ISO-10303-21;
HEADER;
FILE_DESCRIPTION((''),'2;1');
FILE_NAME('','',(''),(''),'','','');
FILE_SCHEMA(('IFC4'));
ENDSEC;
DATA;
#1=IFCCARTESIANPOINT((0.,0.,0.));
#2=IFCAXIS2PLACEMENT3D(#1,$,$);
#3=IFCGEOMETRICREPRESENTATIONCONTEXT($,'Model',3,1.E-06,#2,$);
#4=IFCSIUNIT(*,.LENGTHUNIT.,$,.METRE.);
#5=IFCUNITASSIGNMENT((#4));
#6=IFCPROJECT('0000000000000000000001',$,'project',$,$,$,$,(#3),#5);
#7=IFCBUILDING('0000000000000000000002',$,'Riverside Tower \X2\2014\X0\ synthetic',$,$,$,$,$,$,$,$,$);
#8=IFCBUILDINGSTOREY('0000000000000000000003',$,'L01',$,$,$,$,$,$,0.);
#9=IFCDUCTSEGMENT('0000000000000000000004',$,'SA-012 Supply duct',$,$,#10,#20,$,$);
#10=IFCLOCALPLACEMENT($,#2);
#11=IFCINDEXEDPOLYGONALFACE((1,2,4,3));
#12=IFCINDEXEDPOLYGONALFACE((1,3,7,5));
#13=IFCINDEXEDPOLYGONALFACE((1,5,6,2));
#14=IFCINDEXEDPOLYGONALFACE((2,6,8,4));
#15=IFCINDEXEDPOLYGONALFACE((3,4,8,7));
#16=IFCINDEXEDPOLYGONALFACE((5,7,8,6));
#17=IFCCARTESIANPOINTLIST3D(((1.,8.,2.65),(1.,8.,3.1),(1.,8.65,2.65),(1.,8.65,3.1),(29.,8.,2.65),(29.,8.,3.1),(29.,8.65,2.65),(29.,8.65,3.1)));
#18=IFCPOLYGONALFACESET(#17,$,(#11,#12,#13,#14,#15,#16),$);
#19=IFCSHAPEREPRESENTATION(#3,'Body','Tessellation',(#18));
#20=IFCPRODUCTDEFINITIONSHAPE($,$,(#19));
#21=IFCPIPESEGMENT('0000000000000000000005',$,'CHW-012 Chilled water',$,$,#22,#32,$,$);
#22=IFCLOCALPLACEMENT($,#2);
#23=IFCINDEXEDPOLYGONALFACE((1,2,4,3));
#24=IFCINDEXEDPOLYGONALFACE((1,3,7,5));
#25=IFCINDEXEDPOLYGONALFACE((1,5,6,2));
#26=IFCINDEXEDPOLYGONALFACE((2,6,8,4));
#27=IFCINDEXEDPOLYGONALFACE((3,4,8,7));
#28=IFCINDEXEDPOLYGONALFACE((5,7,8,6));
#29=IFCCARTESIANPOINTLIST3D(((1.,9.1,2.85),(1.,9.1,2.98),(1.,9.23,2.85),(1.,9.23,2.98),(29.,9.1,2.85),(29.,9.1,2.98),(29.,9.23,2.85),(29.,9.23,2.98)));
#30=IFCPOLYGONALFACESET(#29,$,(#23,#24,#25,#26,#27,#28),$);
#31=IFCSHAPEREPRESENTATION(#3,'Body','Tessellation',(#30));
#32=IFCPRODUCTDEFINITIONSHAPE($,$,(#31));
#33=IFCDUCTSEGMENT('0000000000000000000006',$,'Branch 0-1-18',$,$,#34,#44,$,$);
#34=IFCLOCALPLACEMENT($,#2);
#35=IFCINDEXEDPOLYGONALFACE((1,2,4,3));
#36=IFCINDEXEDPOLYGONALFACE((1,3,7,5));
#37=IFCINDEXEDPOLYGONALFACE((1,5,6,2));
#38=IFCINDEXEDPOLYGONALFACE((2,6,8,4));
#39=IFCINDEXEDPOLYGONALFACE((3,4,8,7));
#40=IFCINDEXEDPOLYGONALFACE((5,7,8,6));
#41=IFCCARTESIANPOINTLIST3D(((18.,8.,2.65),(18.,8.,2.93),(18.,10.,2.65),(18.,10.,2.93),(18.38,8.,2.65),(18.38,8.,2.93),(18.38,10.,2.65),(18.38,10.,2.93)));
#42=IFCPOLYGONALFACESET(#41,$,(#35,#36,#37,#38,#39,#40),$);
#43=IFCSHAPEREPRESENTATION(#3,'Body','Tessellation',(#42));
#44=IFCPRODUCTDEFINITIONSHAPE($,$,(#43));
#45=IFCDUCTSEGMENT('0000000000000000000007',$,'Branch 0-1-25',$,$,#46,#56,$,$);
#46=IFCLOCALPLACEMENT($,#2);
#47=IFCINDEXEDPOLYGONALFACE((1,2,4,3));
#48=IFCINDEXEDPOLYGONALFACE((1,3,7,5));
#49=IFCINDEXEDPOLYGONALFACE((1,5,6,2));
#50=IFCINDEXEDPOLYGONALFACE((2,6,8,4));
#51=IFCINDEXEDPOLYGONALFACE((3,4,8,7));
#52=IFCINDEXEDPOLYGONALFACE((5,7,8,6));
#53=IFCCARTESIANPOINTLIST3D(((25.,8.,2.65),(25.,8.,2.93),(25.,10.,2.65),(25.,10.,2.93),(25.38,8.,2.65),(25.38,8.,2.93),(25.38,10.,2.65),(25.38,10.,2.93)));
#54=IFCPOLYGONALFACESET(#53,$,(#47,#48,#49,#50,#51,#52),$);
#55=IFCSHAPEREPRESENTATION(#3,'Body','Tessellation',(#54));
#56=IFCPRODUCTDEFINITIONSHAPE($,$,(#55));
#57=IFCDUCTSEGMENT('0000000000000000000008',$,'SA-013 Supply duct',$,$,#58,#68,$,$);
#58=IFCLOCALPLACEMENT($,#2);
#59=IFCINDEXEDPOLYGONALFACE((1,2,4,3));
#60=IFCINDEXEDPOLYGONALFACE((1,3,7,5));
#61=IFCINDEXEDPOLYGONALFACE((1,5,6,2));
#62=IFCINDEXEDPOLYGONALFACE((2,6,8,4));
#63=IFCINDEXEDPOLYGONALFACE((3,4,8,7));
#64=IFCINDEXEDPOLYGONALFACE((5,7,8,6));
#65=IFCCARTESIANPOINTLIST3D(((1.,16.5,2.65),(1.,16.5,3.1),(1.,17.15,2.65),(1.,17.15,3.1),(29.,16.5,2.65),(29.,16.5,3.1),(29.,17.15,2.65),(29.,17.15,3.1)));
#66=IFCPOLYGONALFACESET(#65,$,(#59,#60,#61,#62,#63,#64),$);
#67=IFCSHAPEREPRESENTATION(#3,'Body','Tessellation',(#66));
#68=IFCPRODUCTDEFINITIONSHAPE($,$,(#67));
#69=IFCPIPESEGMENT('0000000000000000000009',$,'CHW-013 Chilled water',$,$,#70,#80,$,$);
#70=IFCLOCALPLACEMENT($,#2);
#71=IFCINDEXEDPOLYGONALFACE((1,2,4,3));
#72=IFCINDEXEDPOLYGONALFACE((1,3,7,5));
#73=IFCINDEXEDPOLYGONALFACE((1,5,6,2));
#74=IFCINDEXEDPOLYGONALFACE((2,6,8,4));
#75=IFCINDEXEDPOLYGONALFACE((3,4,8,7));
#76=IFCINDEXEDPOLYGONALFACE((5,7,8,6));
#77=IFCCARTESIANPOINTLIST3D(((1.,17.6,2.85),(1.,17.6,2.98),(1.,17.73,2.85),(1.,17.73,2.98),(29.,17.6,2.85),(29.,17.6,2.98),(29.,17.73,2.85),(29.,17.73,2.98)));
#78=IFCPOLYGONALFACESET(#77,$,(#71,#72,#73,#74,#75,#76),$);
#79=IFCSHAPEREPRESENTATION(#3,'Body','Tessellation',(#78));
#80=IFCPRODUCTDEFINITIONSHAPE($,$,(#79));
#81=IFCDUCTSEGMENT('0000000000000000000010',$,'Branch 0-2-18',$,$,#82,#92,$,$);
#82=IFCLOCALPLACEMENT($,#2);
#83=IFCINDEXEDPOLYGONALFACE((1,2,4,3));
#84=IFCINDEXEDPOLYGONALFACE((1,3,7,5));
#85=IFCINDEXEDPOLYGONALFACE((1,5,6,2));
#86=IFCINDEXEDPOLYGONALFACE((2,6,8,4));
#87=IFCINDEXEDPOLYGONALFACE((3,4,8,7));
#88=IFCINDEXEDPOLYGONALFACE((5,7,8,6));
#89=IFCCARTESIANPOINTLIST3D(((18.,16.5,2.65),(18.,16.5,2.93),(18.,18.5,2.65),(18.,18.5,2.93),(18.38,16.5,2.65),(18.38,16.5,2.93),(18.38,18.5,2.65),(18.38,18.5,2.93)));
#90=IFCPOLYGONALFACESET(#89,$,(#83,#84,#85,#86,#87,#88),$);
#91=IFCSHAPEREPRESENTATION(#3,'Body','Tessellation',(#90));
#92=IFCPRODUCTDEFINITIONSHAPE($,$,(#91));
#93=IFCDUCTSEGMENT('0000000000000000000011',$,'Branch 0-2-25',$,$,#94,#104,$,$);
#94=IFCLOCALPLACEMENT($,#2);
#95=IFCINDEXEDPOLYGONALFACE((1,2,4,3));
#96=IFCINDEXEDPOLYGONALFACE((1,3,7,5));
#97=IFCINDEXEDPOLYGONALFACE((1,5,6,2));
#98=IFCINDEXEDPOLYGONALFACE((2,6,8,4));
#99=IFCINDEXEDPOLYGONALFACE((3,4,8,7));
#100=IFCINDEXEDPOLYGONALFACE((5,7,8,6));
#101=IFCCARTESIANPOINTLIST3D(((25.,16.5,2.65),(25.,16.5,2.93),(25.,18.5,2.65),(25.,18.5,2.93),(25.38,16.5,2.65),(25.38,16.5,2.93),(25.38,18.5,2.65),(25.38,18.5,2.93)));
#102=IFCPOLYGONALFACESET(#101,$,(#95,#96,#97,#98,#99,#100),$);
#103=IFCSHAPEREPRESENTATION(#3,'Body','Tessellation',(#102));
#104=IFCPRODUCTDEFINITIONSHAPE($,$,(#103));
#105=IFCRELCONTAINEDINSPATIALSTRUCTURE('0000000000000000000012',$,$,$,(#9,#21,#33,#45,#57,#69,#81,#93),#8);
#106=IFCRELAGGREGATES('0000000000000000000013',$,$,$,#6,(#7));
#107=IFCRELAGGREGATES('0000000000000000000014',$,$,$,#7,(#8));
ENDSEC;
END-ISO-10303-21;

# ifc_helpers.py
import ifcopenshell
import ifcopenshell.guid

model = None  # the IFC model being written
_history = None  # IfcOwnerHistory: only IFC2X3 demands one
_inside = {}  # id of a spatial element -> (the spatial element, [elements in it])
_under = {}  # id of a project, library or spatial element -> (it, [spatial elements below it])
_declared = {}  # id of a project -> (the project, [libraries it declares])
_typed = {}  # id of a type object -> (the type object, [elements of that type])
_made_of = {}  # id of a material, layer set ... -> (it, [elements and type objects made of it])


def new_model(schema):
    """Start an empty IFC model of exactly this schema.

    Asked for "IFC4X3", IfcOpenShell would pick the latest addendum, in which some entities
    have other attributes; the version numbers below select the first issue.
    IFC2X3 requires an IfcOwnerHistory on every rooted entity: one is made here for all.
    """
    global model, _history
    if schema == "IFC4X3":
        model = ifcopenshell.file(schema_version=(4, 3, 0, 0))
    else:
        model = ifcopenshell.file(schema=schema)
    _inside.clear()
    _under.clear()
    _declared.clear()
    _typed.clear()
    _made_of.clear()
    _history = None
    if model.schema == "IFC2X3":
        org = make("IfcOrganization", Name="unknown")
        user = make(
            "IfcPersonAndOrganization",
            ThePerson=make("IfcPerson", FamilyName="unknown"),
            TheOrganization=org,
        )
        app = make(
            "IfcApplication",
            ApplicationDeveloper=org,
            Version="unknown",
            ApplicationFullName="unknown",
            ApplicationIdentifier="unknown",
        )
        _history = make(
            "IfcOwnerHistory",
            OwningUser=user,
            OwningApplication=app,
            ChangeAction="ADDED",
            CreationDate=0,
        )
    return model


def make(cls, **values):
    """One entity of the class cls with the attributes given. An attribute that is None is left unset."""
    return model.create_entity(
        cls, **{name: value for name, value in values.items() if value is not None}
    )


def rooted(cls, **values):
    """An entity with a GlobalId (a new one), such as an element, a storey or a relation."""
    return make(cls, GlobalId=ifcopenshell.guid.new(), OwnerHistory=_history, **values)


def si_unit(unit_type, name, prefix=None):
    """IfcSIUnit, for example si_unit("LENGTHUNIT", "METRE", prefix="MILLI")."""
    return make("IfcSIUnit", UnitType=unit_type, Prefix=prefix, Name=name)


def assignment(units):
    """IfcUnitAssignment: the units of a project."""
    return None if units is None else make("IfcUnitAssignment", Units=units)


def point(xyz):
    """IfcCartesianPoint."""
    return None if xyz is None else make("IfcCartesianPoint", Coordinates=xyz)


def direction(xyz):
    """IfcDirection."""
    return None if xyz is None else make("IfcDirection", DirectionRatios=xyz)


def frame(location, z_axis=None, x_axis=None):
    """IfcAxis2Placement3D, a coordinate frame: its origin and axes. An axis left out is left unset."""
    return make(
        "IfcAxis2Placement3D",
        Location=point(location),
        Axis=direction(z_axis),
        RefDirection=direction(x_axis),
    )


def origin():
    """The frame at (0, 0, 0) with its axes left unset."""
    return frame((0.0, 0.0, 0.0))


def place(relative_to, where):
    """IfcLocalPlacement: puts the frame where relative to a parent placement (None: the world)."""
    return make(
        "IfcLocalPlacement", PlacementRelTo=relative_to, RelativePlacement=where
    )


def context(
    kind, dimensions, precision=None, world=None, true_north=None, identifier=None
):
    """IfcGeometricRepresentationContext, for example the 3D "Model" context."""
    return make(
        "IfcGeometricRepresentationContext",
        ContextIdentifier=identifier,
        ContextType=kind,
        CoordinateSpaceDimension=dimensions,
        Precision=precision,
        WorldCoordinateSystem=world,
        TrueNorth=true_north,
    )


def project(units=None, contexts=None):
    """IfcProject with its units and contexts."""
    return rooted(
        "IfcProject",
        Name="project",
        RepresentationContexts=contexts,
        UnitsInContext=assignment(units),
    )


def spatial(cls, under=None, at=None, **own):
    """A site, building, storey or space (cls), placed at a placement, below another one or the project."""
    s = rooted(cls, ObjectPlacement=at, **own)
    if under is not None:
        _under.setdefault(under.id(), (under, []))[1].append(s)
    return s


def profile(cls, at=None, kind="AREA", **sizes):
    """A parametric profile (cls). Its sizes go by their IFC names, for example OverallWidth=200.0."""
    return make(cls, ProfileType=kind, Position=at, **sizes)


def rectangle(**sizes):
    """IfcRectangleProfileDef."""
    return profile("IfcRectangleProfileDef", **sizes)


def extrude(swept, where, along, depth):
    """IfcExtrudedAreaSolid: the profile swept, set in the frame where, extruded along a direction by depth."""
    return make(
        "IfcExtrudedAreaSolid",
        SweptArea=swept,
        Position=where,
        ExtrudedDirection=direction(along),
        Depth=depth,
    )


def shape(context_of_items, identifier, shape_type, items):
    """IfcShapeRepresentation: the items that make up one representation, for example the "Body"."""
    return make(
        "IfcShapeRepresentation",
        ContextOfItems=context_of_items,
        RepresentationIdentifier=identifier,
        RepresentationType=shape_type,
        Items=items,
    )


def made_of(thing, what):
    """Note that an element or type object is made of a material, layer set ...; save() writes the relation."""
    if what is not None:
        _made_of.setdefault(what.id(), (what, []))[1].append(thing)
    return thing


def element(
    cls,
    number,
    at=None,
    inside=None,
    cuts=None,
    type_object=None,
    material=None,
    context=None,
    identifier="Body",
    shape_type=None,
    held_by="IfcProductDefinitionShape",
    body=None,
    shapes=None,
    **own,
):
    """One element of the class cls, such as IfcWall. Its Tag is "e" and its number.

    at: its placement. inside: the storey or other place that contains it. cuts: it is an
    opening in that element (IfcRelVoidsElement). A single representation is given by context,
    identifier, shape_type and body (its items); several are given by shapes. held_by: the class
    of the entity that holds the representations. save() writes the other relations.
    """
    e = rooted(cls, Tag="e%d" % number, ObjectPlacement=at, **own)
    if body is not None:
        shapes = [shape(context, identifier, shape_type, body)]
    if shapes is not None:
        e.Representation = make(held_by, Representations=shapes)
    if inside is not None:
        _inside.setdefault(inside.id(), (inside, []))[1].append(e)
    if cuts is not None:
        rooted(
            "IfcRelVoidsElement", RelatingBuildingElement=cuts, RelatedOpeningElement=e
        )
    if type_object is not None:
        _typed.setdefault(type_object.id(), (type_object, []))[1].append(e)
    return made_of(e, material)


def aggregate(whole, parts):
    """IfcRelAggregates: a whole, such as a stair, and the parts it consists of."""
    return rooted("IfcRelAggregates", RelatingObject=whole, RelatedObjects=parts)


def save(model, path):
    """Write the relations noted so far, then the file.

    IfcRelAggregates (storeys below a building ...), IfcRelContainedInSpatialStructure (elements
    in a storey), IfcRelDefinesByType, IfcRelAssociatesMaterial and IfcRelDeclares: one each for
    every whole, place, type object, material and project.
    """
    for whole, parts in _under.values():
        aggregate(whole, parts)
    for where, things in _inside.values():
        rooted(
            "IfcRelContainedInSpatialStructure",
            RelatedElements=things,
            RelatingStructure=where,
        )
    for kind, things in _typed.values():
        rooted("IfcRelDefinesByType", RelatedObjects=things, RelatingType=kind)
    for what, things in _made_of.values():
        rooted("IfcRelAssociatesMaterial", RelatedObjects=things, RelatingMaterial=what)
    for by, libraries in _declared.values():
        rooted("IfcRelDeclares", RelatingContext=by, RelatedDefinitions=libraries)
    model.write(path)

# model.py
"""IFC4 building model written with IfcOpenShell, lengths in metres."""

from ifc_helpers import new_model, si_unit, frame, origin, place, context, project, spatial, rectangle, extrude, element, save


model = new_model("IFC4")

# Units and contexts
model_context = context("Model", 3, precision=1e-06, world=origin())
ifc_project = project(units=[si_unit("LENGTHUNIT", "METRE")], contexts=[model_context])

# Building, storey
building = spatial("IfcBuilding", under=ifc_project, Name="Riverside Tower — synthetic")
storey = spatial("IfcBuildingStorey", under=building, Name="L01", Elevation=0.0)

# Duct segment
duct_segment_1_placement = place(None, frame((15.0, 8.325, 2.65)))
element("IfcDuctSegment", 1, at=duct_segment_1_placement, inside=storey, Name="SA-012 Supply duct", context=model_context, shape_type="SweptSolid", body=[
    extrude(rectangle(XDim=28.0, YDim=0.65), origin(), (0.0, 0.0, 1.0), 0.45),
])

# Pipe segment
pipe_segment_1_placement = place(None, frame((15.0, 9.165, 2.85)))
element("IfcPipeSegment", 2, at=pipe_segment_1_placement, inside=storey, Name="CHW-012 Chilled water", context=model_context, shape_type="SweptSolid", body=[
    extrude(rectangle(XDim=28.0, YDim=0.13), origin(), (0.0, 0.0, 1.0), 0.13),
])

# Duct segments
for number, where, name in (
    (3, (18.19, 9.0, 2.65), "Branch 0-1-18"),
    (4, (25.19, 9.0, 2.65), "Branch 0-1-25"),
):
    element("IfcDuctSegment", number, at=place(None, frame(where)), inside=storey, Name=name, context=model_context, shape_type="SweptSolid", body=[
        extrude(rectangle(XDim=0.38, YDim=2.0), origin(), (0.0, 0.0, 1.0), 0.28),
    ])
duct_segment_2_placement = place(None, frame((15.0, 16.825, 2.65)))
element("IfcDuctSegment", 5, at=duct_segment_2_placement, inside=storey, Name="SA-013 Supply duct", context=model_context, shape_type="SweptSolid", body=[
    extrude(rectangle(XDim=28.0, YDim=0.65), origin(), (0.0, 0.0, 1.0), 0.45),
])

# Pipe segment
pipe_segment_2_placement = place(None, frame((15.0, 17.665, 2.85)))
element("IfcPipeSegment", 6, at=pipe_segment_2_placement, inside=storey, Name="CHW-013 Chilled water", context=model_context, shape_type="SweptSolid", body=[
    extrude(rectangle(XDim=28.0, YDim=0.13), origin(), (0.0, 0.0, 1.0), 0.13),
])

# Duct segments
for number, where, name in (
    (7, (18.19, 17.5, 2.65), "Branch 0-2-18"),
    (8, (25.19, 17.5, 2.65), "Branch 0-2-25"),
):
    element("IfcDuctSegment", number, at=place(None, frame(where)), inside=storey, Name=name, context=model_context, shape_type="SweptSolid", body=[
        extrude(rectangle(XDim=0.38, YDim=2.0), origin(), (0.0, 0.0, 1.0), 0.28),
    ])

save(model, "model.ifc")
